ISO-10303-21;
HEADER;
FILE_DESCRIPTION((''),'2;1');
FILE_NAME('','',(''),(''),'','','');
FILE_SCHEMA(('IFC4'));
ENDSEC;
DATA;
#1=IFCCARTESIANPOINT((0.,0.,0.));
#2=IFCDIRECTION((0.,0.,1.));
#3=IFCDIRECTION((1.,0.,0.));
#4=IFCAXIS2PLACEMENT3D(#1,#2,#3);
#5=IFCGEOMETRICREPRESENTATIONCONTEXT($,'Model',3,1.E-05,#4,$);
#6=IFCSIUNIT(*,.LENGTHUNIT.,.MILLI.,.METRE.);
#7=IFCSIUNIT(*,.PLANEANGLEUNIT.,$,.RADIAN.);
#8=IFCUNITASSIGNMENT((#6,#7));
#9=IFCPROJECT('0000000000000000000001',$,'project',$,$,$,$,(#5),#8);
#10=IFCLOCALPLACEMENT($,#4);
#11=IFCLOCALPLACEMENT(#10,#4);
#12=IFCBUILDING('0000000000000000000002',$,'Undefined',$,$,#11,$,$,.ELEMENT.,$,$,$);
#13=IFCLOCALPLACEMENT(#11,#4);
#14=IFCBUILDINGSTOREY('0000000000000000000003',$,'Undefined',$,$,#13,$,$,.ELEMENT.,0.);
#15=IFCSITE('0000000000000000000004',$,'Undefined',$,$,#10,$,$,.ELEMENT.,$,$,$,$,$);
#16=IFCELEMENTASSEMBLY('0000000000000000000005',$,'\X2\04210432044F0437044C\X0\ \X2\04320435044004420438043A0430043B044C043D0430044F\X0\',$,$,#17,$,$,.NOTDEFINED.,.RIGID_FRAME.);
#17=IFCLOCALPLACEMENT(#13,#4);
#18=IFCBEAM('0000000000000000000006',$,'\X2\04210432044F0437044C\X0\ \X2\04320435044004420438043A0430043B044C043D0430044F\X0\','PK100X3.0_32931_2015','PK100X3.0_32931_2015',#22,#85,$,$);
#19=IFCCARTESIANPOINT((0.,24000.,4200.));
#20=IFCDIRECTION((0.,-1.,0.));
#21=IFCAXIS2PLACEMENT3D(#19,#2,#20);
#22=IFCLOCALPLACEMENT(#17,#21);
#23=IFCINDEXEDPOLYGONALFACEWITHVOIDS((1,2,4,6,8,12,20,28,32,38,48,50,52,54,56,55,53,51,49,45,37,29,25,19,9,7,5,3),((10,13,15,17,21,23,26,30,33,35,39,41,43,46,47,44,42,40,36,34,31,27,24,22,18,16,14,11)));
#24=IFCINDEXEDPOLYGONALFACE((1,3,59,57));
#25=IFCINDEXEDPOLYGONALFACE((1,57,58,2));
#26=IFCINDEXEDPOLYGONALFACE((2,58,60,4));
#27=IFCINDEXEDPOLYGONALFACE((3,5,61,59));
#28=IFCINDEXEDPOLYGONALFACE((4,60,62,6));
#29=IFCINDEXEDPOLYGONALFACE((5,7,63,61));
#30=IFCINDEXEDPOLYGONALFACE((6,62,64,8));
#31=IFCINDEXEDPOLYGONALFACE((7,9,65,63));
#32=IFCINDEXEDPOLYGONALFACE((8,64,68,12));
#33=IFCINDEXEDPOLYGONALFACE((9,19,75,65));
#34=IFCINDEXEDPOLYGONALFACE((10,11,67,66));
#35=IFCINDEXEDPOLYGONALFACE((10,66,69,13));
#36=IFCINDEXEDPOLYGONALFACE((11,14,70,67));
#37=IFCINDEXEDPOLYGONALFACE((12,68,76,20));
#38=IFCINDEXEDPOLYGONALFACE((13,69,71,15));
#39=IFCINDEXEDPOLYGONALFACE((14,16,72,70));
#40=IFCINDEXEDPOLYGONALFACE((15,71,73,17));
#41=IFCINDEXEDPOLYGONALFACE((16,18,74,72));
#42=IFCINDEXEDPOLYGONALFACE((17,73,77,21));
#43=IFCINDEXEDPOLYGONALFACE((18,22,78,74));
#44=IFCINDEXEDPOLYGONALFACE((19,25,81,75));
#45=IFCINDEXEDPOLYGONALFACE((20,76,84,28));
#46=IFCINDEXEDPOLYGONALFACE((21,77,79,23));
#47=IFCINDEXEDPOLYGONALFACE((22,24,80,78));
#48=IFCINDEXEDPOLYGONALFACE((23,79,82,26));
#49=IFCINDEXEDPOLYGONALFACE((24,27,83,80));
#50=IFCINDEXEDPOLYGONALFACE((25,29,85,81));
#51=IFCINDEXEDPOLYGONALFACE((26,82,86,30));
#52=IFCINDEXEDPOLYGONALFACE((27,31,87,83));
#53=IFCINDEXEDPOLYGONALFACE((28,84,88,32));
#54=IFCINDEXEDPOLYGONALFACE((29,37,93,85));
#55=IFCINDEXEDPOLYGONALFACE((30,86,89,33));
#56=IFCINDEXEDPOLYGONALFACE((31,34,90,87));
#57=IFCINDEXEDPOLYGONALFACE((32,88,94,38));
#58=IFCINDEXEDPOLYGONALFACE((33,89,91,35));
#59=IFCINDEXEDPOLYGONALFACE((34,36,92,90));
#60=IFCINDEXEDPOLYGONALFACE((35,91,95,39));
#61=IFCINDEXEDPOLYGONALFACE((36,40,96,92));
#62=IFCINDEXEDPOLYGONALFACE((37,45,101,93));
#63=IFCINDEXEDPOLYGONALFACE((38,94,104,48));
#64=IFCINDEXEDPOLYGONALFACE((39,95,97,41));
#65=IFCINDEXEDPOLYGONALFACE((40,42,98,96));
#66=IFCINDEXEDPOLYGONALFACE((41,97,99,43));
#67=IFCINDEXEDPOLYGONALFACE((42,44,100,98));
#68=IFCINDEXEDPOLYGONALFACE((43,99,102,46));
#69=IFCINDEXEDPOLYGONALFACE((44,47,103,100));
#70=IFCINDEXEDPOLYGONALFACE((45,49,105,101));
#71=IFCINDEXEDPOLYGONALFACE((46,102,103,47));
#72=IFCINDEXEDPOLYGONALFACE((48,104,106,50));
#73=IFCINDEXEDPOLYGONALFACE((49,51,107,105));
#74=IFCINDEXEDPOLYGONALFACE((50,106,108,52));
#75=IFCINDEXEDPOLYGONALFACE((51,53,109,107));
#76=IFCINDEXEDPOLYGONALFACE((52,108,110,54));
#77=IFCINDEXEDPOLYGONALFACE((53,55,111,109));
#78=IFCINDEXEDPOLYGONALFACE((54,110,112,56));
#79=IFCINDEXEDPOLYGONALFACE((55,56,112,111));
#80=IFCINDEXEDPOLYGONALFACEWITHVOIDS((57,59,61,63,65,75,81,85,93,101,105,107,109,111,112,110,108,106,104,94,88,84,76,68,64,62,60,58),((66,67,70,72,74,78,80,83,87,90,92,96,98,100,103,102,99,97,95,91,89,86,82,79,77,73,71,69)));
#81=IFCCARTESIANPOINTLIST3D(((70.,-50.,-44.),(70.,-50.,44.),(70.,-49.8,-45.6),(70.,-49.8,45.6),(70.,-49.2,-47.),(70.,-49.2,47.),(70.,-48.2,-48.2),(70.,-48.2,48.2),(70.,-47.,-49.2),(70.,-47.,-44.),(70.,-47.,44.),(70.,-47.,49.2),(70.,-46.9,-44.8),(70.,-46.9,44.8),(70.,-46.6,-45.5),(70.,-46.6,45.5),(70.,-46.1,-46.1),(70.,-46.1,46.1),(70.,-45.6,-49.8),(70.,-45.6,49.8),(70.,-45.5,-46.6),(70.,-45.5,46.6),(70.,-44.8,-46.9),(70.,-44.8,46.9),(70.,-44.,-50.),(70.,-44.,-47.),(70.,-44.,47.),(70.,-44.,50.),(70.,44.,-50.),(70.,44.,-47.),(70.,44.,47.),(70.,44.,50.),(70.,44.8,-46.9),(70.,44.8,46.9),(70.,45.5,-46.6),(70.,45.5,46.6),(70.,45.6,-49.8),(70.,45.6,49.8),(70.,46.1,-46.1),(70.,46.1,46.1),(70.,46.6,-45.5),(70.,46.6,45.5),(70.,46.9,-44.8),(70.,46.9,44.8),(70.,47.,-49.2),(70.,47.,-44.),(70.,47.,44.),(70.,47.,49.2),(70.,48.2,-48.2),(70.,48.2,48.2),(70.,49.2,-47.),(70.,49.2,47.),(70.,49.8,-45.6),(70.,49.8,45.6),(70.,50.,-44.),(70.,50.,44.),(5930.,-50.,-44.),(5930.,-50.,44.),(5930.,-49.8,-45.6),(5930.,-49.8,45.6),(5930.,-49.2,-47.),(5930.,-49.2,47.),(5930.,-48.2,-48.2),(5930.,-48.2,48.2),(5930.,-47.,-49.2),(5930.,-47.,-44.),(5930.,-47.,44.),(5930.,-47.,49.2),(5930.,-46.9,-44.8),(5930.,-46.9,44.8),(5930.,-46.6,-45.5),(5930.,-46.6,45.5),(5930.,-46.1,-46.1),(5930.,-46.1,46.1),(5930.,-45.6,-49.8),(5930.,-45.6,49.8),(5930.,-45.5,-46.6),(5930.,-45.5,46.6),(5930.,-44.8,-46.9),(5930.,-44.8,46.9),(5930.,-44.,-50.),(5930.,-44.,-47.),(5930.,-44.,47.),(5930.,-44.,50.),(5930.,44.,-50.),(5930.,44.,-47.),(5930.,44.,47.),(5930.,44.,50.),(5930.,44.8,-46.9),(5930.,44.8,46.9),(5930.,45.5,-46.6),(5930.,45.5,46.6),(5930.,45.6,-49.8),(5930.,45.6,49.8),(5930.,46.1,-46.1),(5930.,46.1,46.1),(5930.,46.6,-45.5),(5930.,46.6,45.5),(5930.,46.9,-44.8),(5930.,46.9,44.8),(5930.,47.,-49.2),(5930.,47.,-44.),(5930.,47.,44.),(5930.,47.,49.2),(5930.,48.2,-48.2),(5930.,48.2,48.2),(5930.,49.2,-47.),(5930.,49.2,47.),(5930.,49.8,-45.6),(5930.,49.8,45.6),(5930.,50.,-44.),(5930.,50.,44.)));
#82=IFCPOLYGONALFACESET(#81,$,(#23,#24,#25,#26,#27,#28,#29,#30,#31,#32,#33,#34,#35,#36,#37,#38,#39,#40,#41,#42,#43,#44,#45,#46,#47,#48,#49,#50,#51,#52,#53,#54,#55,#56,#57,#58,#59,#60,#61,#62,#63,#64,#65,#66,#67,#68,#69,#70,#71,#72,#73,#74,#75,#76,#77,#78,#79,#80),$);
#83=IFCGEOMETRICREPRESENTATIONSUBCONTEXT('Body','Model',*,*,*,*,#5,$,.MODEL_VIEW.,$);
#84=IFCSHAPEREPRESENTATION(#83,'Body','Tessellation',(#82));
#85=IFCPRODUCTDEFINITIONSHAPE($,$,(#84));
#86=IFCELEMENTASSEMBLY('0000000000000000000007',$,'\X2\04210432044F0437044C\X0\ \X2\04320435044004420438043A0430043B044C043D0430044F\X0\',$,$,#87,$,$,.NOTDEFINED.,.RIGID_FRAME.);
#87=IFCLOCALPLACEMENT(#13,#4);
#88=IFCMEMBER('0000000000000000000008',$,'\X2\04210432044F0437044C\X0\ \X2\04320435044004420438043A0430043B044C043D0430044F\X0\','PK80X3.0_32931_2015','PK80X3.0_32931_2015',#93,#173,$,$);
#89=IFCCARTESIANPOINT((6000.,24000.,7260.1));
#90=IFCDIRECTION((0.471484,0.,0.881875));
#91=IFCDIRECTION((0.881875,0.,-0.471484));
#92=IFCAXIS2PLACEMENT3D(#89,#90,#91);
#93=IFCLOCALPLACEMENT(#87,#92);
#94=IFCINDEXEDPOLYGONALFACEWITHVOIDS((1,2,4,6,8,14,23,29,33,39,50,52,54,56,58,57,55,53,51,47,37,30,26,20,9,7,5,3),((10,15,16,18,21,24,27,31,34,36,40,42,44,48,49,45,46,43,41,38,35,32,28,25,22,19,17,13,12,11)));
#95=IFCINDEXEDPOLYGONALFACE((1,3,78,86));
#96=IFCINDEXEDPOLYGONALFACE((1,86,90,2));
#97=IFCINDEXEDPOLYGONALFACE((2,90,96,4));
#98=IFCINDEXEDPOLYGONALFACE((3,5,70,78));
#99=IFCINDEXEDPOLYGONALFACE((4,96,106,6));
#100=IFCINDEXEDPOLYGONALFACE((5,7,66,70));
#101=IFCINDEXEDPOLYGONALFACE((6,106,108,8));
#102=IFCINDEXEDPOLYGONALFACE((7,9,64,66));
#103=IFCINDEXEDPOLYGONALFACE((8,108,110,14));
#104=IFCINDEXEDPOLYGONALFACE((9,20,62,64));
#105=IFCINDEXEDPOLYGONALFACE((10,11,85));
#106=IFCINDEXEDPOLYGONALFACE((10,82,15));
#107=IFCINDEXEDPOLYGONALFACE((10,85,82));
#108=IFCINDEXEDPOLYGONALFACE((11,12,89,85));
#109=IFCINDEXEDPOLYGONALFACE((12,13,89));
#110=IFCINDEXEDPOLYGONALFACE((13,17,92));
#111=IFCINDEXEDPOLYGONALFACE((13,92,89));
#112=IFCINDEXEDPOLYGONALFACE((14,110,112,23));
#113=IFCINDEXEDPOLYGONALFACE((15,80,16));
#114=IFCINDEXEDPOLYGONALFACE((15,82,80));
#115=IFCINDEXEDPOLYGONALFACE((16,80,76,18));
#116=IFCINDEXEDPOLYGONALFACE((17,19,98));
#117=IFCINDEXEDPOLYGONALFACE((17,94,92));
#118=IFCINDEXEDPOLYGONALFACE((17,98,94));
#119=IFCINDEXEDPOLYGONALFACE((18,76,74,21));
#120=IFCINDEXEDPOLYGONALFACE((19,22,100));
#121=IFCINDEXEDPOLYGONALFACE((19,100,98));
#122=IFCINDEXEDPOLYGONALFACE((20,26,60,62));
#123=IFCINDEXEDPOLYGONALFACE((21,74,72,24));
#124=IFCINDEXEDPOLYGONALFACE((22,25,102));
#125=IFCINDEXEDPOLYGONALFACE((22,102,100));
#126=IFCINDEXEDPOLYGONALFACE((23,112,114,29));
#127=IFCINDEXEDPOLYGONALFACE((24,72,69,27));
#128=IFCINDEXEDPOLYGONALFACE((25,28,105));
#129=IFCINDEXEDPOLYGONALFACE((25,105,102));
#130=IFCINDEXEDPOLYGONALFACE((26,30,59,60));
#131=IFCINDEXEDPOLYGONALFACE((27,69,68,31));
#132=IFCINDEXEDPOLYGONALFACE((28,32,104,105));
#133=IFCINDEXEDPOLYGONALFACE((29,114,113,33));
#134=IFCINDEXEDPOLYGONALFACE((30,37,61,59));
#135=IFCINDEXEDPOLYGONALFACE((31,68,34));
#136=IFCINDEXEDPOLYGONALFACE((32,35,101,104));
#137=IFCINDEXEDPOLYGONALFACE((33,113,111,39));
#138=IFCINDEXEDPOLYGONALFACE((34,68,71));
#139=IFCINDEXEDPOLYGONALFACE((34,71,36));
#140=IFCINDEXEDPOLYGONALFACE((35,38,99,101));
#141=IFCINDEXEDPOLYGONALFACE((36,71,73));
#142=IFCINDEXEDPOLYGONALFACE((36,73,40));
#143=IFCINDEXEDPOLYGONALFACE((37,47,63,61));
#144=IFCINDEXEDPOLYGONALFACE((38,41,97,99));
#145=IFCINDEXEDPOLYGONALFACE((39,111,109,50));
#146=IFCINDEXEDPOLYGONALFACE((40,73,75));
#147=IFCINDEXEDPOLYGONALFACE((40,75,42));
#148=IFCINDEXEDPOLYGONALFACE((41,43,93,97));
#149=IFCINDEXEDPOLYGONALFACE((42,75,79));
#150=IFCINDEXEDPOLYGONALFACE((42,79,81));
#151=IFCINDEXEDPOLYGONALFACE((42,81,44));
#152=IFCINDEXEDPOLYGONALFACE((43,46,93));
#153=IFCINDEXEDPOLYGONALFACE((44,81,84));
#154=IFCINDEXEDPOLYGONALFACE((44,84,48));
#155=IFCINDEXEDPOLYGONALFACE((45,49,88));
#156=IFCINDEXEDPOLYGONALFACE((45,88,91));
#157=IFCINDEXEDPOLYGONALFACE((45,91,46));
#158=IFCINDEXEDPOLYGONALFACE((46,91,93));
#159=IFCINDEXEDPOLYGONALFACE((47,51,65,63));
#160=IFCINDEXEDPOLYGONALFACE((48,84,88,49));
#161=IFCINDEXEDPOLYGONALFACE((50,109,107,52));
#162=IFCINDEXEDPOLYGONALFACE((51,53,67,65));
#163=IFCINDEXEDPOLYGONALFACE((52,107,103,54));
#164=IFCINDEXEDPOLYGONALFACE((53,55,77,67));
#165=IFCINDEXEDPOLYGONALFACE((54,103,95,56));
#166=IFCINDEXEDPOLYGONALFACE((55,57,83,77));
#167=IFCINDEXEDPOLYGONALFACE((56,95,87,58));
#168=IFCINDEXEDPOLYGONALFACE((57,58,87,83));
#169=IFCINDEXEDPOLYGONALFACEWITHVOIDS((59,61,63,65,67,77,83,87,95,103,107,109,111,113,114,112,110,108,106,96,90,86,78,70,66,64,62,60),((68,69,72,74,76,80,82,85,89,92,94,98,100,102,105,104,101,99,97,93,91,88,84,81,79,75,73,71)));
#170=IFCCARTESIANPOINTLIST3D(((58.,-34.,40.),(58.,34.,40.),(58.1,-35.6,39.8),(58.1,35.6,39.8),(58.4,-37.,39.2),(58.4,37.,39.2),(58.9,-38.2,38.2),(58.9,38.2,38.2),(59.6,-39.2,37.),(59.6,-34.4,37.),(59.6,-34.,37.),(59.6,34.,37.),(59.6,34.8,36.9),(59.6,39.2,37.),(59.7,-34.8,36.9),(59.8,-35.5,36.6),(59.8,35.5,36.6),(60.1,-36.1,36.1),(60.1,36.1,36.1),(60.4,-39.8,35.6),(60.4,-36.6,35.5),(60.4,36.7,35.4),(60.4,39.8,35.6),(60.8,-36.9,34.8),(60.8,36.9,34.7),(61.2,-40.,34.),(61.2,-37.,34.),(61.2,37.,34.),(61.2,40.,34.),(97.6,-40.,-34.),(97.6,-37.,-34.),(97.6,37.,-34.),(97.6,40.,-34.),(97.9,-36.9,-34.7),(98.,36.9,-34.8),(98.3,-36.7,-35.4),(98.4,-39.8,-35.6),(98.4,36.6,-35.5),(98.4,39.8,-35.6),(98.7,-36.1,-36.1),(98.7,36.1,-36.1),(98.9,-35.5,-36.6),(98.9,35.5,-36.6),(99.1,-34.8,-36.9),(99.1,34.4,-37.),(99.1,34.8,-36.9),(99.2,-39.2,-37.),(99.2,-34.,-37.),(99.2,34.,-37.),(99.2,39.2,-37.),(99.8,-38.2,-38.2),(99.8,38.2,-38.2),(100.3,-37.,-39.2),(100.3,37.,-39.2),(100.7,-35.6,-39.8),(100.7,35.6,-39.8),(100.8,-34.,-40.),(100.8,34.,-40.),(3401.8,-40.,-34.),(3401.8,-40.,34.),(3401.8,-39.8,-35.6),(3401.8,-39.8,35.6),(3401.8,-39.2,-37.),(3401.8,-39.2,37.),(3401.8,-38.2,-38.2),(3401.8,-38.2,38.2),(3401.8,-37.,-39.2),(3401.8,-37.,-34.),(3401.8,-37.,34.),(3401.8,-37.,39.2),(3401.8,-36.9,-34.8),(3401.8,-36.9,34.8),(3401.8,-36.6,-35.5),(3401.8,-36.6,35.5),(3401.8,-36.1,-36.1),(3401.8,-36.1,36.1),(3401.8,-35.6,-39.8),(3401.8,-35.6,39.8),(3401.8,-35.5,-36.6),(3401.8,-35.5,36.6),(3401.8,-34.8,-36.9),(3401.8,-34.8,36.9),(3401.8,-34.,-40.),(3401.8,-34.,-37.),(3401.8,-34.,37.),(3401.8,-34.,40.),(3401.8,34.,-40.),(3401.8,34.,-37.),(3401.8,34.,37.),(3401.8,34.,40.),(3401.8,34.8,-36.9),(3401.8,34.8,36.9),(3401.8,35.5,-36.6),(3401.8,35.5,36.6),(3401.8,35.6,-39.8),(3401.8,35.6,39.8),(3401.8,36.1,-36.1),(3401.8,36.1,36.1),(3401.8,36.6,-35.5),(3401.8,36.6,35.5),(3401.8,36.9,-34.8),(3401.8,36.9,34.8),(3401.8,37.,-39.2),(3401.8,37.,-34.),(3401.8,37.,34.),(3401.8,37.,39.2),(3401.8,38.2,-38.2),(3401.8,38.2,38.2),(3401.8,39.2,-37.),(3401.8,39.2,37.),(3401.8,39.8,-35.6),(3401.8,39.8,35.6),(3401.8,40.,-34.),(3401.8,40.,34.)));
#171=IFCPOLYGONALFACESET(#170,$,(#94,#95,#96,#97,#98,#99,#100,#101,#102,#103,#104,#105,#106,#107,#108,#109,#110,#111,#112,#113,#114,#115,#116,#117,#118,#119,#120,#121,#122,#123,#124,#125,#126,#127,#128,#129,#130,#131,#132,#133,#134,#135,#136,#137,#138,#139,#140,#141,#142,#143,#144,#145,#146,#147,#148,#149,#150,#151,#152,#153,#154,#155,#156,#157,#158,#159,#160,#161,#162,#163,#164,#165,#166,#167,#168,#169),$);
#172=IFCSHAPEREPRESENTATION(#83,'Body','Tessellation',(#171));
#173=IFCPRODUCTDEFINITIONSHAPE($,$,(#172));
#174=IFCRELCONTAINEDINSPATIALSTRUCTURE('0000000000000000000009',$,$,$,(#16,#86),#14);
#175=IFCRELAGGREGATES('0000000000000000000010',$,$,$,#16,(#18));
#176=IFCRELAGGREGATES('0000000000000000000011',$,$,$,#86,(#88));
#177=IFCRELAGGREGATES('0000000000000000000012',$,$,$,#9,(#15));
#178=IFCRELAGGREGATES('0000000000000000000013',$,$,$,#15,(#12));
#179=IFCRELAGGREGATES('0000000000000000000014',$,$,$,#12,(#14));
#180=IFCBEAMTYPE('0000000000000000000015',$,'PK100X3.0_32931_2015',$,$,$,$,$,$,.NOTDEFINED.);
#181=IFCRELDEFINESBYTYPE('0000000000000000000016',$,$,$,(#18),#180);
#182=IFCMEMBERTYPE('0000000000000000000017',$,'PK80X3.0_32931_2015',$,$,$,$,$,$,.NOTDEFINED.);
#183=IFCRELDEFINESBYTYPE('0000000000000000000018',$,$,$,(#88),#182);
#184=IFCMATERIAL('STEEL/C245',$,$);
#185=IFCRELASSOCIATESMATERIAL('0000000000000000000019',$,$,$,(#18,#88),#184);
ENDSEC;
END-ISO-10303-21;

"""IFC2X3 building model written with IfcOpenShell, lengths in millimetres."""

from ifc_helpers import new_model, si_unit, frame, origin_with_axes, origin_2d_with_axis, place, context, subcontext, project, spatial, hollow_rectangle, extrude, clip, halfspace, material, type_object, element, aggregate, save


model = new_model("IFC2X3")

# Units and contexts
model_context = context("Model", 3, precision=1e-05, world=origin_with_axes())
body_context = subcontext(model_context, "Body", "Model", "MODEL_VIEW")
ifc_project = project(units=[si_unit("LENGTHUNIT", "METRE", prefix="MILLI"), si_unit("PLANEANGLEUNIT", "RADIAN")], contexts=[model_context])

# Site, building, storey
site_placement = place(None, origin_with_axes())
site = spatial("IfcSite", under=ifc_project, at=site_placement, Name="Undefined", CompositionType="ELEMENT")
building_placement = place(site_placement, origin_with_axes())
building = spatial("IfcBuilding", under=site, at=building_placement, Name="Undefined", CompositionType="ELEMENT")
storey_placement = place(building_placement, origin_with_axes())
storey = spatial("IfcBuildingStorey", under=building, at=storey_placement, Name="Undefined", CompositionType="ELEMENT", Elevation=0.0)

# Element assembly, beam
assembly_1_placement = place(storey_placement, origin_with_axes())
assembly_1 = element("IfcElementAssembly", 1, at=assembly_1_placement, inside=storey, Name="Связь вертикальная", AssemblyPlace="NOTDEFINED", PredefinedType="RIGID_FRAME")
ifc_material_1 = material(Name="STEEL/C245")
beam_type_1 = type_object("IfcBeamType", Name="PK100X3.0_32931_2015", PredefinedType="NOTDEFINED")
beam_1_placement = place(assembly_1_placement, frame((0.0, 24000.0, 4200.0), z_axis=(0.0, 0.0, 1.0), x_axis=(0.0, -1.0, 0.0)))
beam_1 = element("IfcBeam", 2, at=beam_1_placement, type_object=beam_type_1, material=ifc_material_1, Name="Связь вертикальная", Description="PK100X3.0_32931_2015", ObjectType="PK100X3.0_32931_2015", context=body_context, shape_type="Clipping", body=[
    clip(clip(extrude(hollow_rectangle(XDim=100.0, YDim=100.0, WallThickness=3.0, InnerFilletRadius=3.0, OuterFilletRadius=6.0, at=origin_2d_with_axis()), frame((5930.0, 0.0, 0.0), z_axis=(-1.0, 0.0, 0.0), x_axis=(0.0, -1.0, 0.0)), (0.0, 0.0, 1.0), 5860.0), halfspace(frame((5930.0, 0.0, -164.1), z_axis=(-1.0, 0.0, 0.0), x_axis=(0.0, 1.0, 0.0)), True)), halfspace(frame((70.0, 0.0, 380.8), z_axis=(-1.0, 0.0, 0.0), x_axis=(0.0, 1.0, 0.0)), False)),
])
aggregate(assembly_1, [beam_1])

# Element assembly, member
assembly_2_placement = place(storey_placement, origin_with_axes())
assembly_2 = element("IfcElementAssembly", 3, at=assembly_2_placement, inside=storey, Name="Связь вертикальная", AssemblyPlace="NOTDEFINED", PredefinedType="RIGID_FRAME")
member_type_1 = type_object("IfcMemberType", Name="PK80X3.0_32931_2015", PredefinedType="NOTDEFINED")
member_1_placement = place(assembly_2_placement, frame((6000.0, 24000.0, 7260.1), z_axis=(0.471484, 0.0, 0.881875), x_axis=(0.881875, 0.0, -0.471484)))
member_1 = element("IfcMember", 4, at=member_1_placement, type_object=member_type_1, material=ifc_material_1, Name="Связь вертикальная", Description="PK80X3.0_32931_2015", ObjectType="PK80X3.0_32931_2015", context=body_context, shape_type="Clipping", body=[
    clip(extrude(hollow_rectangle(XDim=80.0, YDim=80.0, WallThickness=3.0, InnerFilletRadius=3.0, OuterFilletRadius=6.0, at=origin_2d_with_axis()), frame((3401.8, 0.0, 0.0), z_axis=(-1.0, 0.0, 0.0), x_axis=(0.0, -1.0, 0.0)), (0.0, 0.0, 1.0), 3377.7), halfspace(frame((147.4, 0.0, -127.2), z_axis=(-0.881875, 0.0, -0.471484), x_axis=(0.471484, 0.0, -0.881875)), False)),
])
aggregate(assembly_2, [member_1])

save(model, "model.ifc")
